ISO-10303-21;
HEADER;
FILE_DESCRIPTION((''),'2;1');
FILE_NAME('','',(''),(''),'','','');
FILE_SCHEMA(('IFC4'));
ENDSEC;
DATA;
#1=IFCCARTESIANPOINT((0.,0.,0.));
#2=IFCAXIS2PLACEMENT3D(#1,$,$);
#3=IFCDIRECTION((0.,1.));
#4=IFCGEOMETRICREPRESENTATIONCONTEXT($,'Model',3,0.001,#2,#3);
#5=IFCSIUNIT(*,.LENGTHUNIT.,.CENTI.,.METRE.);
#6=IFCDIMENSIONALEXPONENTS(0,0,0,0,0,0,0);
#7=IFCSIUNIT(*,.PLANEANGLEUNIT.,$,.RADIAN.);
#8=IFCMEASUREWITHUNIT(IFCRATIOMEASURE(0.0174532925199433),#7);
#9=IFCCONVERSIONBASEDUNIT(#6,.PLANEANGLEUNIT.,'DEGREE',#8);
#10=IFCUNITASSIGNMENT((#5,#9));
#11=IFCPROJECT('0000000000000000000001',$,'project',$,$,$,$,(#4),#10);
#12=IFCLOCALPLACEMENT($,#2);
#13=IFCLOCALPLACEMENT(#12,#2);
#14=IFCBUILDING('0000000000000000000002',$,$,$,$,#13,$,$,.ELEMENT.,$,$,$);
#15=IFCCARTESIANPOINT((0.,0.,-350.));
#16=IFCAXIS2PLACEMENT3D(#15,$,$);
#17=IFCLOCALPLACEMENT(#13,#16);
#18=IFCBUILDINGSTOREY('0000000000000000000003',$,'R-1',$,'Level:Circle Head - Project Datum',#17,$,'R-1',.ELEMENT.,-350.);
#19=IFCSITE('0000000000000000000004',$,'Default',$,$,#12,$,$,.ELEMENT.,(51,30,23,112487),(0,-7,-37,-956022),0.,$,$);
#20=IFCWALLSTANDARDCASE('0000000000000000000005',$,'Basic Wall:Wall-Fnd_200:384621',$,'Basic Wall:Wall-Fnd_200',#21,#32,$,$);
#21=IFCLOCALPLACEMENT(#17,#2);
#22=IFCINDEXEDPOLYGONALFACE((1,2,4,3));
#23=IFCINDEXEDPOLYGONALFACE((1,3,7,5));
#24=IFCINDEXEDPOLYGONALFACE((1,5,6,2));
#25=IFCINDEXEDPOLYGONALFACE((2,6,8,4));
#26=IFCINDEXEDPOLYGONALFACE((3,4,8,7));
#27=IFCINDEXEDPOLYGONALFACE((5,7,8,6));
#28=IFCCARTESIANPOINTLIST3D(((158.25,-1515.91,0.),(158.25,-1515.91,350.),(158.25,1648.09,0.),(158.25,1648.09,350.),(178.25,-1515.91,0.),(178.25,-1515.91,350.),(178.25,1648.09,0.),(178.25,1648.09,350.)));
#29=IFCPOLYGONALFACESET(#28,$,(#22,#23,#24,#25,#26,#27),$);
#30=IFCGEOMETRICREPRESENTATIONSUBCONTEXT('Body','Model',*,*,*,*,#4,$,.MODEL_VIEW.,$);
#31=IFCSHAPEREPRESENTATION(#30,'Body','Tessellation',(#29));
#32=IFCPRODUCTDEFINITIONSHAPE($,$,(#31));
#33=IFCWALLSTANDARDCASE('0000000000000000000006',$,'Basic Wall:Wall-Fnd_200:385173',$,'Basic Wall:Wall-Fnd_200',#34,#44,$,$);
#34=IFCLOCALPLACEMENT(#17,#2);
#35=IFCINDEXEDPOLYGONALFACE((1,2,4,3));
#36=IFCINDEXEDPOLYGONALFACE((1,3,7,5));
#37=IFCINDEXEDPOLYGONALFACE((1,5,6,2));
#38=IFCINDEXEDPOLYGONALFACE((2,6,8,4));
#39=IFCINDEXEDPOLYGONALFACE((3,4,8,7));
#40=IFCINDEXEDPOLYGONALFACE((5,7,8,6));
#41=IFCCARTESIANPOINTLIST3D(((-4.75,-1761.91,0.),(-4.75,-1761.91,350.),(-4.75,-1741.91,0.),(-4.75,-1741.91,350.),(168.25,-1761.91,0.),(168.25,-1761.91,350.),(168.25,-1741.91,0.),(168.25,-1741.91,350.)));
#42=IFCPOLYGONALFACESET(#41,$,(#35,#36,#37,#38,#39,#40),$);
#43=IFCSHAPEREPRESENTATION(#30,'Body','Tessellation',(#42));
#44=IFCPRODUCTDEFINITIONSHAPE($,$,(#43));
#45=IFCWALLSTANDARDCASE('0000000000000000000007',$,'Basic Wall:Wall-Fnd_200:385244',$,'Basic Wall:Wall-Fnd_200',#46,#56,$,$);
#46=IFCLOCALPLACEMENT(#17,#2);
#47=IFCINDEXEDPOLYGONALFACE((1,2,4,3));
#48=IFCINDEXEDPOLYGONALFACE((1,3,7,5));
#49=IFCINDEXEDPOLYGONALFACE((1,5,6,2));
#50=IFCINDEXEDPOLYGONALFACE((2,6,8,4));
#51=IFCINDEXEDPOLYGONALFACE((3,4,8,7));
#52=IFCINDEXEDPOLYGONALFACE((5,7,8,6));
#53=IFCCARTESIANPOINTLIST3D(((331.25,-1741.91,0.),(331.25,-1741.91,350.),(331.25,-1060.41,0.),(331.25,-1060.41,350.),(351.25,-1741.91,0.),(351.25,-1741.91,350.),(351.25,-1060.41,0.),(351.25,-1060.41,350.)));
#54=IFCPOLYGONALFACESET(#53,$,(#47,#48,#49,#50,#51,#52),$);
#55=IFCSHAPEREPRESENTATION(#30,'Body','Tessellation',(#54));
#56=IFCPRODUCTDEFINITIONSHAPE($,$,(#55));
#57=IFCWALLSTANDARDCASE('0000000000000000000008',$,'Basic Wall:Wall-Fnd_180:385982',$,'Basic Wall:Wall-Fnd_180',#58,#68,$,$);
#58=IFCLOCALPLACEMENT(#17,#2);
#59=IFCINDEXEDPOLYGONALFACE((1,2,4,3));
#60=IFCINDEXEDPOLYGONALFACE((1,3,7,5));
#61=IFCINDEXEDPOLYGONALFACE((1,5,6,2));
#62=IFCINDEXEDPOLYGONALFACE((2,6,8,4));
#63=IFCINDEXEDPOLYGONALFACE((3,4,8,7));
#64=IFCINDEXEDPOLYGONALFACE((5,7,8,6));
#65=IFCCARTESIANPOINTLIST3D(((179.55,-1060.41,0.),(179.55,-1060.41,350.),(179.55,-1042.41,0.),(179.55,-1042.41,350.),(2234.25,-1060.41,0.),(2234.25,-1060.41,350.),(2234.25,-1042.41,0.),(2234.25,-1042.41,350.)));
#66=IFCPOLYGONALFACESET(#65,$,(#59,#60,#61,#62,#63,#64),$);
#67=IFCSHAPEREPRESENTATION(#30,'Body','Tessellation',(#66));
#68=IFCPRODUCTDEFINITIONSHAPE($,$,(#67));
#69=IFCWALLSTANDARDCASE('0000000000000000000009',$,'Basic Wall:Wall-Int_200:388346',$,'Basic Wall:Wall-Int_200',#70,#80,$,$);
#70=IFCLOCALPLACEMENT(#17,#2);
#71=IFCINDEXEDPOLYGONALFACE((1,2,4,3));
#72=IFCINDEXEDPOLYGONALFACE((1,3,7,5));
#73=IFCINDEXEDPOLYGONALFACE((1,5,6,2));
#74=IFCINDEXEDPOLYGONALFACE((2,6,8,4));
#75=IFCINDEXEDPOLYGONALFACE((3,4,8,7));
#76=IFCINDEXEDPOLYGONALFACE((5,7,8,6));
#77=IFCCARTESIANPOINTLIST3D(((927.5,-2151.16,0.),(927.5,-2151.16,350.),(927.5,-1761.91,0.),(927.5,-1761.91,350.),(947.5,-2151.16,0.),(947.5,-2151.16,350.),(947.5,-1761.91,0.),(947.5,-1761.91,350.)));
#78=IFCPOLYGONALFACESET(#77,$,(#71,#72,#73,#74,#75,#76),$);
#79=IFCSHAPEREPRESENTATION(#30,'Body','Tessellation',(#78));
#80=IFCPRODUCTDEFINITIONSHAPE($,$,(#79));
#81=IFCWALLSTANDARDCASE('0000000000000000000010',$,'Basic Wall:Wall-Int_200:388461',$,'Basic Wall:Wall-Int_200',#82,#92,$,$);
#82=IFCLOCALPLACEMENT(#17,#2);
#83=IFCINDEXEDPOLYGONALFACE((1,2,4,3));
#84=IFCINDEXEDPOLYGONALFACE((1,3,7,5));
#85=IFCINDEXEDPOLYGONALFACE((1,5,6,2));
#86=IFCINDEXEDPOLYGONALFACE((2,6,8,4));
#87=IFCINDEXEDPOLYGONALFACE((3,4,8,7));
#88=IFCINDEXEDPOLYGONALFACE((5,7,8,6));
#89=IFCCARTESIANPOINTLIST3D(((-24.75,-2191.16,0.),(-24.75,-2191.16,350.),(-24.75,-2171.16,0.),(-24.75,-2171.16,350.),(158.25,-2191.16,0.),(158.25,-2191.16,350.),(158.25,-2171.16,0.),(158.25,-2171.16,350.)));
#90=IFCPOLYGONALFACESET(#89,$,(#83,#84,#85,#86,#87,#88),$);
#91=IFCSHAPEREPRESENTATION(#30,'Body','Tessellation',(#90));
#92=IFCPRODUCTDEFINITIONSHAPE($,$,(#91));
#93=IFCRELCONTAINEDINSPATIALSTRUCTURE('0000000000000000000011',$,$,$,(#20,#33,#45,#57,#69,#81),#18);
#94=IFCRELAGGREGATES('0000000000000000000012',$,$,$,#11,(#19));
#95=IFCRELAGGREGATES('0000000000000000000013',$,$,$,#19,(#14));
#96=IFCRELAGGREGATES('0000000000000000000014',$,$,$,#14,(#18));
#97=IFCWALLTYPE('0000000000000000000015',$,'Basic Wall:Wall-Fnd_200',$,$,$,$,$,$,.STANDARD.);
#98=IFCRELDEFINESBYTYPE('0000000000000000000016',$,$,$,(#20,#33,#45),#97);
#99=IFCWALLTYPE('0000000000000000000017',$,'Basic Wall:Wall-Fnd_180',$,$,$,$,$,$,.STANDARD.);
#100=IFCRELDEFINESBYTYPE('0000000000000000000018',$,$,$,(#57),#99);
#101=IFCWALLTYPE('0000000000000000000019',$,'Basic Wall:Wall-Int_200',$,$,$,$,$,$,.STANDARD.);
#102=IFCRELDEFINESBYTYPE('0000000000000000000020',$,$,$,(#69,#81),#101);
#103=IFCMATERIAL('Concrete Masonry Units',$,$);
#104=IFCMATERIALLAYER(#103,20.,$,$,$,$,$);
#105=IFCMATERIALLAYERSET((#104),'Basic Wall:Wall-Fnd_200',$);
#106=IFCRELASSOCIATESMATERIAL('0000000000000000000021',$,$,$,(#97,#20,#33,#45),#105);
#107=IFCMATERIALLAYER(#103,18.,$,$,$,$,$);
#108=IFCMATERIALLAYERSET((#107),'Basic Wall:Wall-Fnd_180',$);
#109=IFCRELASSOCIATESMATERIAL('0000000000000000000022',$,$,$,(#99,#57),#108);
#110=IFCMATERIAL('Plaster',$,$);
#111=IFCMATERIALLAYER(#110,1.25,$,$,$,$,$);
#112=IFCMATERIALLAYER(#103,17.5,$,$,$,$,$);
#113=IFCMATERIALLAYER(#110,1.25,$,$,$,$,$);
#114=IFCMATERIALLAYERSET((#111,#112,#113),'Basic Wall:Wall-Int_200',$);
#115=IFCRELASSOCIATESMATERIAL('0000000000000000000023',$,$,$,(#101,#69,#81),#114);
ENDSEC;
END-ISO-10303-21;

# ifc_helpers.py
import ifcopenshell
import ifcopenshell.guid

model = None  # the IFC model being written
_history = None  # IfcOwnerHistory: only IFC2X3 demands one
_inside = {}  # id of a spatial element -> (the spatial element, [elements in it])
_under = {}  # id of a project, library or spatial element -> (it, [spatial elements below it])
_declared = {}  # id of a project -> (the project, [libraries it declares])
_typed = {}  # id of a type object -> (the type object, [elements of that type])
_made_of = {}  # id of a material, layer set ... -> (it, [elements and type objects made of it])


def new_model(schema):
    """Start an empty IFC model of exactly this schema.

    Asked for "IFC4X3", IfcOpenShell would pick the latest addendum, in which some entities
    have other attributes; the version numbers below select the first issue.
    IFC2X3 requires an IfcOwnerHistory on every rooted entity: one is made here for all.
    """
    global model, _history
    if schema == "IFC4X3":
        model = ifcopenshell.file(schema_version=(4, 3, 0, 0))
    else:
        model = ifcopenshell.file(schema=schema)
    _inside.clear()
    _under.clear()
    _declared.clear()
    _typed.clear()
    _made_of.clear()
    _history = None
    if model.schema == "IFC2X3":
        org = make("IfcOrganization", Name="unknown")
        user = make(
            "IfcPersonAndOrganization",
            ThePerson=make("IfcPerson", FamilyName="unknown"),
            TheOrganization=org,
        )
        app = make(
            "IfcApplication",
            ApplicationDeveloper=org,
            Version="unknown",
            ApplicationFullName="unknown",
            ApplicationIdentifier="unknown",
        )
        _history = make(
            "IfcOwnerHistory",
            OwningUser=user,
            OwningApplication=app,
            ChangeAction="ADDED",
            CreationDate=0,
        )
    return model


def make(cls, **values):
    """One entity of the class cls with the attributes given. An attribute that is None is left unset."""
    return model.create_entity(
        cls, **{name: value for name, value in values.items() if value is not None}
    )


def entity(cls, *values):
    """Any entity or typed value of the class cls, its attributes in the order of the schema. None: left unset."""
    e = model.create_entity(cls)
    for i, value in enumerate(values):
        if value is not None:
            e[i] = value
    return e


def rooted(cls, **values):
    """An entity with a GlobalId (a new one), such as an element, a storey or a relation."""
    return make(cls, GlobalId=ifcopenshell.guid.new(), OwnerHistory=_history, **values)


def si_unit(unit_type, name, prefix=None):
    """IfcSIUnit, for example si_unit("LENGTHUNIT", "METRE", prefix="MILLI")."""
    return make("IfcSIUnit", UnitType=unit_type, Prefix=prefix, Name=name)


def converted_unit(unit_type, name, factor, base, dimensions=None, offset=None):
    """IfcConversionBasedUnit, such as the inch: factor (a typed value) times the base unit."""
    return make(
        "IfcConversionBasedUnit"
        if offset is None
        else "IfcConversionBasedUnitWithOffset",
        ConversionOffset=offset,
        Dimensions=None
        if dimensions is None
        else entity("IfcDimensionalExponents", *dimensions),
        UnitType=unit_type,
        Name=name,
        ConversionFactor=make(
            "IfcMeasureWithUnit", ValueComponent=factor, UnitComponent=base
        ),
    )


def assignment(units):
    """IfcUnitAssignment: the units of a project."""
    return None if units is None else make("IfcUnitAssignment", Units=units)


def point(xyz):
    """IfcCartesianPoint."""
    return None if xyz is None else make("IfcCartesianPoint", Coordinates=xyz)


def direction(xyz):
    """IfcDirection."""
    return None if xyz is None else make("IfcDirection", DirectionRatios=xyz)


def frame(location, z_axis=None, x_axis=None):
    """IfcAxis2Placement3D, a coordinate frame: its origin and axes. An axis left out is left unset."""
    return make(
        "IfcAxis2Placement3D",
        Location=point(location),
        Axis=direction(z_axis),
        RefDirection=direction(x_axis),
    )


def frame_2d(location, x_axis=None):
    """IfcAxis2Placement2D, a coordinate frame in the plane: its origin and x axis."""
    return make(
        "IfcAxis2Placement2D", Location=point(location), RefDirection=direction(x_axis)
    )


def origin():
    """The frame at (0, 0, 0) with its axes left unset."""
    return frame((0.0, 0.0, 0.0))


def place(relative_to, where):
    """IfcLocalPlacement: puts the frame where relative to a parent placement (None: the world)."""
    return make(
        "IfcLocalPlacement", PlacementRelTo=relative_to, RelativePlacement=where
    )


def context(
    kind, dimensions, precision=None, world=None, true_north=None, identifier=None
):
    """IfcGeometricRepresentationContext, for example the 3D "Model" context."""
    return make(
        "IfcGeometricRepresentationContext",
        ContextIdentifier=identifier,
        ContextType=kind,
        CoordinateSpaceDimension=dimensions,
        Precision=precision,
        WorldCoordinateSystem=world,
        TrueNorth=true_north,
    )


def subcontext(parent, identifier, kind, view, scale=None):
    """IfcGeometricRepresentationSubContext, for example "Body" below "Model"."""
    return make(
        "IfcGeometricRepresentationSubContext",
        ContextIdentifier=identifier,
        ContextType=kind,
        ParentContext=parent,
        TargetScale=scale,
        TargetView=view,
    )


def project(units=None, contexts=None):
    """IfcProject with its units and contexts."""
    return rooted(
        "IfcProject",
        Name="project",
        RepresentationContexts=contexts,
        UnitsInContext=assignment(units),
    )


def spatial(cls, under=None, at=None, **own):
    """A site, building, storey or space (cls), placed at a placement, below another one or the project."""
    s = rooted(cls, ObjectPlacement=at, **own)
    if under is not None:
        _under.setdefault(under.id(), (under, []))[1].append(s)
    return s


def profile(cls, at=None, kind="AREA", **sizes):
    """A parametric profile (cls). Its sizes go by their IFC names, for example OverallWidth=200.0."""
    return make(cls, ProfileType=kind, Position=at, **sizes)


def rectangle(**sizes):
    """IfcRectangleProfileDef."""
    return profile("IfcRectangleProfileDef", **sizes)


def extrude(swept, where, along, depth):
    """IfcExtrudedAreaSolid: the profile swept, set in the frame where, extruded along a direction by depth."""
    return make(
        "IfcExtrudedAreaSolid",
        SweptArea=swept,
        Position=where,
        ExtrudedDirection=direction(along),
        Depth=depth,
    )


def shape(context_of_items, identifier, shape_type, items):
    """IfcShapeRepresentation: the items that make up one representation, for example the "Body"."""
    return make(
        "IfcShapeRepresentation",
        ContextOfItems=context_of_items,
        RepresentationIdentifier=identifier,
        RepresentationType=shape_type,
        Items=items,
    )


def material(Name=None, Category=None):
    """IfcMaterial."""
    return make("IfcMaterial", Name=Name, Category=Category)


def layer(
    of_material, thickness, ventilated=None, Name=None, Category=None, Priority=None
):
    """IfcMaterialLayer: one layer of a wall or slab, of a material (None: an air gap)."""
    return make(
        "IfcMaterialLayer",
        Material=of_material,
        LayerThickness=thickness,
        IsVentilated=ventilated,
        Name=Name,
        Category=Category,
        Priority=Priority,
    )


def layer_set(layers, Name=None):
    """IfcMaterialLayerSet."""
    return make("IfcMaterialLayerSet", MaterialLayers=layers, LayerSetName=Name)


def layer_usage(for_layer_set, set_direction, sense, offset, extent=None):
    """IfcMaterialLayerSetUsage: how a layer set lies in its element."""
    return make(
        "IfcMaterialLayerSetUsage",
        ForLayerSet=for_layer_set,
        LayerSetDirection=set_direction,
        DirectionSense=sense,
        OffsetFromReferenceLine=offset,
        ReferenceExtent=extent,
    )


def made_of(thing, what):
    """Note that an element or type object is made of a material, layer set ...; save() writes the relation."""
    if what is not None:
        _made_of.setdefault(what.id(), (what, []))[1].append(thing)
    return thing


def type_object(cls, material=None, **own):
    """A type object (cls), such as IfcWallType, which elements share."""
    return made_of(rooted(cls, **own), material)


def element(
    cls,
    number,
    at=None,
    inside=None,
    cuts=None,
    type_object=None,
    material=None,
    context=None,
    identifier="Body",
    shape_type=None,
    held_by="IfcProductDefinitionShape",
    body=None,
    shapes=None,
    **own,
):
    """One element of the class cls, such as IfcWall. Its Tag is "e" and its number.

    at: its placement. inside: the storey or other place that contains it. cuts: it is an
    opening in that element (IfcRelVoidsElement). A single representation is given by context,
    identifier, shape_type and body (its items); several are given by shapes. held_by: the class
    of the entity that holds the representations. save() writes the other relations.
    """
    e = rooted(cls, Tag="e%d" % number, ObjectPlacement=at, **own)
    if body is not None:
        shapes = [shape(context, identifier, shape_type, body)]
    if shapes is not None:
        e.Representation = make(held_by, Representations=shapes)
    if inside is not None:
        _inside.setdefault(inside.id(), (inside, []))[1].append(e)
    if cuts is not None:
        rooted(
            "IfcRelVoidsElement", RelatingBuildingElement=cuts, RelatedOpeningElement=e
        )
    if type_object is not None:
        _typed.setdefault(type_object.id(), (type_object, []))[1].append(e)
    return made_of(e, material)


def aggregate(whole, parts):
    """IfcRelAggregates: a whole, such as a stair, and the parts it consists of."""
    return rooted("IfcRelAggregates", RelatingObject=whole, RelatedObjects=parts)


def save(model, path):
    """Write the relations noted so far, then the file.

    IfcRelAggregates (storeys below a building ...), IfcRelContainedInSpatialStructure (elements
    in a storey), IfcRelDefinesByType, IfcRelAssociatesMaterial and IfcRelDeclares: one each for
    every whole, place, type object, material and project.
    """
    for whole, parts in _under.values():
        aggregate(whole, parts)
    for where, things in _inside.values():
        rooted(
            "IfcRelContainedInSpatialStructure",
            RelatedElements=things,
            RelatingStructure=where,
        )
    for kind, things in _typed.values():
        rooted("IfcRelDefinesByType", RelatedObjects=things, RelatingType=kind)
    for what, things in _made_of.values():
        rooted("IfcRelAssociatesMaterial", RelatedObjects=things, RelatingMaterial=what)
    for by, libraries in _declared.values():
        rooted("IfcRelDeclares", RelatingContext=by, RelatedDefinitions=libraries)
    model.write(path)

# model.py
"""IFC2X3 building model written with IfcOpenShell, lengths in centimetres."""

from ifc_helpers import new_model, entity, si_unit, converted_unit, direction, frame, frame_2d, origin, place, context, subcontext, project, spatial, rectangle, extrude, material, layer, layer_set, layer_usage, type_object, element, save


model = new_model("IFC2X3")

# Units and contexts
model_context = context("Model", 3, precision=0.001, world=origin(), true_north=direction((0.0, 1.0)))
body_context = subcontext(model_context, "Body", "Model", "MODEL_VIEW")
ifc_project = project(units=[si_unit("LENGTHUNIT", "METRE", prefix="CENTI"), converted_unit("PLANEANGLEUNIT", "DEGREE", entity("IfcRatioMeasure", 0.0174532925199433), si_unit("PLANEANGLEUNIT", "RADIAN"), dimensions=[0, 0, 0, 0, 0, 0, 0])], contexts=[model_context])

# Site, building, storey
site_placement = place(None, origin())
site = spatial("IfcSite", under=ifc_project, at=site_placement, Name="Default", CompositionType="ELEMENT", RefLatitude=(51, 30, 23, 112487), RefLongitude=(0, -7, -37, -956022), RefElevation=0.0)
building_placement = place(site_placement, origin())
building = spatial("IfcBuilding", under=site, at=building_placement, CompositionType="ELEMENT")
storey_placement = place(building_placement, frame((0.0, 0.0, -350.0)))
storey = spatial("IfcBuildingStorey", under=building, at=storey_placement, Name="R-1", ObjectType="Level:Circle Head - Project Datum", LongName="R-1", CompositionType="ELEMENT", Elevation=-350.0)

# Walls
ifc_material_1 = material(Name="Concrete Masonry Units")
ifc_layer_1 = layer(ifc_material_1, 20.0)
ifc_layer_set_1 = layer_set([ifc_layer_1], Name="Basic Wall:Wall-Fnd_200")
ifc_layer_usage_1 = layer_usage(ifc_layer_set_1, "AXIS2", "NEGATIVE", 10.0)
wall_type_1 = type_object("IfcWallType", Name="Basic Wall:Wall-Fnd_200", PredefinedType="STANDARD", material=ifc_layer_set_1)
wall_1_placement = place(storey_placement, frame((168.25, -1515.91, 0.0), z_axis=(0.0, 0.0, 1.0), x_axis=(0.0, 1.0, 0.0)))
element("IfcWallStandardCase", 1, at=wall_1_placement, inside=storey, type_object=wall_type_1, material=ifc_layer_usage_1, Name="Basic Wall:Wall-Fnd_200:384621", ObjectType="Basic Wall:Wall-Fnd_200", context=body_context, shape_type="SweptSolid", body=[
    extrude(rectangle(XDim=3164.0, YDim=20.0, at=frame_2d((1582.0, 0.0), x_axis=(-1.0, 0.0))), origin(), (0.0, 0.0, 1.0), 350.0),
])
ifc_layer_usage_2 = layer_usage(ifc_layer_set_1, "AXIS2", "POSITIVE", -10.0)
wall_2_placement = place(storey_placement, frame((168.25, -1751.91, 0.0), z_axis=(0.0, 0.0, 1.0), x_axis=(-1.0, 0.0, 0.0)))
element("IfcWallStandardCase", 2, at=wall_2_placement, inside=storey, type_object=wall_type_1, material=ifc_layer_usage_2, Name="Basic Wall:Wall-Fnd_200:385173", ObjectType="Basic Wall:Wall-Fnd_200", context=body_context, shape_type="SweptSolid", body=[
    extrude(rectangle(XDim=173.0, YDim=20.0, at=frame_2d((86.5, 0.0), x_axis=(-1.0, 0.0))), origin(), (0.0, 0.0, 1.0), 350.0),
])
ifc_layer_usage_3 = layer_usage(ifc_layer_set_1, "AXIS2", "NEGATIVE", 10.0)
wall_3_placement = place(storey_placement, frame((341.25, -1741.91, 0.0), z_axis=(0.0, 0.0, 1.0), x_axis=(0.0, 1.0, 0.0)))
element("IfcWallStandardCase", 3, at=wall_3_placement, inside=storey, type_object=wall_type_1, material=ifc_layer_usage_3, Name="Basic Wall:Wall-Fnd_200:385244", ObjectType="Basic Wall:Wall-Fnd_200", context=body_context, shape_type="SweptSolid", body=[
    extrude(rectangle(XDim=681.5, YDim=20.0, at=frame_2d((340.75, 0.0), x_axis=(-1.0, 0.0))), origin(), (0.0, 0.0, 1.0), 350.0),
])
ifc_layer_2 = layer(ifc_material_1, 18.0)
ifc_layer_set_2 = layer_set([ifc_layer_2], Name="Basic Wall:Wall-Fnd_180")
ifc_layer_usage_4 = layer_usage(ifc_layer_set_2, "AXIS2", "NEGATIVE", 9.0)
wall_type_2 = type_object("IfcWallType", Name="Basic Wall:Wall-Fnd_180", PredefinedType="STANDARD", material=ifc_layer_set_2)
wall_4_placement = place(storey_placement, frame((179.55, -1051.41, 0.0)))
element("IfcWallStandardCase", 4, at=wall_4_placement, inside=storey, type_object=wall_type_2, material=ifc_layer_usage_4, Name="Basic Wall:Wall-Fnd_180:385982", ObjectType="Basic Wall:Wall-Fnd_180", context=body_context, shape_type="SweptSolid", body=[
    extrude(rectangle(XDim=2054.7, YDim=18.0, at=frame_2d((1027.35, 0.0), x_axis=(-1.0, 0.0))), origin(), (0.0, 0.0, 1.0), 350.0),
])
ifc_material_2 = material(Name="Plaster")
ifc_layer_3 = layer(ifc_material_2, 1.25)
ifc_layer_4 = layer(ifc_material_1, 17.5)
ifc_layer_5 = layer(ifc_material_2, 1.25)
ifc_layer_set_3 = layer_set([ifc_layer_3, ifc_layer_4, ifc_layer_5], Name="Basic Wall:Wall-Int_200")
ifc_layer_usage_5 = layer_usage(ifc_layer_set_3, "AXIS2", "NEGATIVE", 10.0)
wall_type_3 = type_object("IfcWallType", Name="Basic Wall:Wall-Int_200", PredefinedType="STANDARD", material=ifc_layer_set_3)
wall_5_placement = place(storey_placement, frame((937.5, -1761.91, 0.0), z_axis=(0.0, 0.0, 1.0), x_axis=(0.0, -1.0, 0.0)))
element("IfcWallStandardCase", 5, at=wall_5_placement, inside=storey, type_object=wall_type_3, material=ifc_layer_usage_5, Name="Basic Wall:Wall-Int_200:388346", ObjectType="Basic Wall:Wall-Int_200", context=body_context, shape_type="SweptSolid", body=[
    extrude(rectangle(XDim=389.25, YDim=20.0, at=frame_2d((194.62, 0.0), x_axis=(-1.0, 0.0))), origin(), (0.0, 0.0, 1.0), 350.0),
])
ifc_layer_usage_6 = layer_usage(ifc_layer_set_3, "AXIS2", "POSITIVE", -10.0)
wall_6_placement = place(storey_placement, frame((158.25, -2181.16, 0.0), z_axis=(0.0, 0.0, 1.0), x_axis=(-1.0, 0.0, 0.0)))
element("IfcWallStandardCase", 6, at=wall_6_placement, inside=storey, type_object=wall_type_3, material=ifc_layer_usage_6, Name="Basic Wall:Wall-Int_200:388461", ObjectType="Basic Wall:Wall-Int_200", context=body_context, shape_type="SweptSolid", body=[
    extrude(rectangle(XDim=183.0, YDim=20.0, at=frame_2d((91.5, 0.0), x_axis=(-1.0, 0.0))), origin(), (0.0, 0.0, 1.0), 350.0),
])

save(model, "model.ifc")
